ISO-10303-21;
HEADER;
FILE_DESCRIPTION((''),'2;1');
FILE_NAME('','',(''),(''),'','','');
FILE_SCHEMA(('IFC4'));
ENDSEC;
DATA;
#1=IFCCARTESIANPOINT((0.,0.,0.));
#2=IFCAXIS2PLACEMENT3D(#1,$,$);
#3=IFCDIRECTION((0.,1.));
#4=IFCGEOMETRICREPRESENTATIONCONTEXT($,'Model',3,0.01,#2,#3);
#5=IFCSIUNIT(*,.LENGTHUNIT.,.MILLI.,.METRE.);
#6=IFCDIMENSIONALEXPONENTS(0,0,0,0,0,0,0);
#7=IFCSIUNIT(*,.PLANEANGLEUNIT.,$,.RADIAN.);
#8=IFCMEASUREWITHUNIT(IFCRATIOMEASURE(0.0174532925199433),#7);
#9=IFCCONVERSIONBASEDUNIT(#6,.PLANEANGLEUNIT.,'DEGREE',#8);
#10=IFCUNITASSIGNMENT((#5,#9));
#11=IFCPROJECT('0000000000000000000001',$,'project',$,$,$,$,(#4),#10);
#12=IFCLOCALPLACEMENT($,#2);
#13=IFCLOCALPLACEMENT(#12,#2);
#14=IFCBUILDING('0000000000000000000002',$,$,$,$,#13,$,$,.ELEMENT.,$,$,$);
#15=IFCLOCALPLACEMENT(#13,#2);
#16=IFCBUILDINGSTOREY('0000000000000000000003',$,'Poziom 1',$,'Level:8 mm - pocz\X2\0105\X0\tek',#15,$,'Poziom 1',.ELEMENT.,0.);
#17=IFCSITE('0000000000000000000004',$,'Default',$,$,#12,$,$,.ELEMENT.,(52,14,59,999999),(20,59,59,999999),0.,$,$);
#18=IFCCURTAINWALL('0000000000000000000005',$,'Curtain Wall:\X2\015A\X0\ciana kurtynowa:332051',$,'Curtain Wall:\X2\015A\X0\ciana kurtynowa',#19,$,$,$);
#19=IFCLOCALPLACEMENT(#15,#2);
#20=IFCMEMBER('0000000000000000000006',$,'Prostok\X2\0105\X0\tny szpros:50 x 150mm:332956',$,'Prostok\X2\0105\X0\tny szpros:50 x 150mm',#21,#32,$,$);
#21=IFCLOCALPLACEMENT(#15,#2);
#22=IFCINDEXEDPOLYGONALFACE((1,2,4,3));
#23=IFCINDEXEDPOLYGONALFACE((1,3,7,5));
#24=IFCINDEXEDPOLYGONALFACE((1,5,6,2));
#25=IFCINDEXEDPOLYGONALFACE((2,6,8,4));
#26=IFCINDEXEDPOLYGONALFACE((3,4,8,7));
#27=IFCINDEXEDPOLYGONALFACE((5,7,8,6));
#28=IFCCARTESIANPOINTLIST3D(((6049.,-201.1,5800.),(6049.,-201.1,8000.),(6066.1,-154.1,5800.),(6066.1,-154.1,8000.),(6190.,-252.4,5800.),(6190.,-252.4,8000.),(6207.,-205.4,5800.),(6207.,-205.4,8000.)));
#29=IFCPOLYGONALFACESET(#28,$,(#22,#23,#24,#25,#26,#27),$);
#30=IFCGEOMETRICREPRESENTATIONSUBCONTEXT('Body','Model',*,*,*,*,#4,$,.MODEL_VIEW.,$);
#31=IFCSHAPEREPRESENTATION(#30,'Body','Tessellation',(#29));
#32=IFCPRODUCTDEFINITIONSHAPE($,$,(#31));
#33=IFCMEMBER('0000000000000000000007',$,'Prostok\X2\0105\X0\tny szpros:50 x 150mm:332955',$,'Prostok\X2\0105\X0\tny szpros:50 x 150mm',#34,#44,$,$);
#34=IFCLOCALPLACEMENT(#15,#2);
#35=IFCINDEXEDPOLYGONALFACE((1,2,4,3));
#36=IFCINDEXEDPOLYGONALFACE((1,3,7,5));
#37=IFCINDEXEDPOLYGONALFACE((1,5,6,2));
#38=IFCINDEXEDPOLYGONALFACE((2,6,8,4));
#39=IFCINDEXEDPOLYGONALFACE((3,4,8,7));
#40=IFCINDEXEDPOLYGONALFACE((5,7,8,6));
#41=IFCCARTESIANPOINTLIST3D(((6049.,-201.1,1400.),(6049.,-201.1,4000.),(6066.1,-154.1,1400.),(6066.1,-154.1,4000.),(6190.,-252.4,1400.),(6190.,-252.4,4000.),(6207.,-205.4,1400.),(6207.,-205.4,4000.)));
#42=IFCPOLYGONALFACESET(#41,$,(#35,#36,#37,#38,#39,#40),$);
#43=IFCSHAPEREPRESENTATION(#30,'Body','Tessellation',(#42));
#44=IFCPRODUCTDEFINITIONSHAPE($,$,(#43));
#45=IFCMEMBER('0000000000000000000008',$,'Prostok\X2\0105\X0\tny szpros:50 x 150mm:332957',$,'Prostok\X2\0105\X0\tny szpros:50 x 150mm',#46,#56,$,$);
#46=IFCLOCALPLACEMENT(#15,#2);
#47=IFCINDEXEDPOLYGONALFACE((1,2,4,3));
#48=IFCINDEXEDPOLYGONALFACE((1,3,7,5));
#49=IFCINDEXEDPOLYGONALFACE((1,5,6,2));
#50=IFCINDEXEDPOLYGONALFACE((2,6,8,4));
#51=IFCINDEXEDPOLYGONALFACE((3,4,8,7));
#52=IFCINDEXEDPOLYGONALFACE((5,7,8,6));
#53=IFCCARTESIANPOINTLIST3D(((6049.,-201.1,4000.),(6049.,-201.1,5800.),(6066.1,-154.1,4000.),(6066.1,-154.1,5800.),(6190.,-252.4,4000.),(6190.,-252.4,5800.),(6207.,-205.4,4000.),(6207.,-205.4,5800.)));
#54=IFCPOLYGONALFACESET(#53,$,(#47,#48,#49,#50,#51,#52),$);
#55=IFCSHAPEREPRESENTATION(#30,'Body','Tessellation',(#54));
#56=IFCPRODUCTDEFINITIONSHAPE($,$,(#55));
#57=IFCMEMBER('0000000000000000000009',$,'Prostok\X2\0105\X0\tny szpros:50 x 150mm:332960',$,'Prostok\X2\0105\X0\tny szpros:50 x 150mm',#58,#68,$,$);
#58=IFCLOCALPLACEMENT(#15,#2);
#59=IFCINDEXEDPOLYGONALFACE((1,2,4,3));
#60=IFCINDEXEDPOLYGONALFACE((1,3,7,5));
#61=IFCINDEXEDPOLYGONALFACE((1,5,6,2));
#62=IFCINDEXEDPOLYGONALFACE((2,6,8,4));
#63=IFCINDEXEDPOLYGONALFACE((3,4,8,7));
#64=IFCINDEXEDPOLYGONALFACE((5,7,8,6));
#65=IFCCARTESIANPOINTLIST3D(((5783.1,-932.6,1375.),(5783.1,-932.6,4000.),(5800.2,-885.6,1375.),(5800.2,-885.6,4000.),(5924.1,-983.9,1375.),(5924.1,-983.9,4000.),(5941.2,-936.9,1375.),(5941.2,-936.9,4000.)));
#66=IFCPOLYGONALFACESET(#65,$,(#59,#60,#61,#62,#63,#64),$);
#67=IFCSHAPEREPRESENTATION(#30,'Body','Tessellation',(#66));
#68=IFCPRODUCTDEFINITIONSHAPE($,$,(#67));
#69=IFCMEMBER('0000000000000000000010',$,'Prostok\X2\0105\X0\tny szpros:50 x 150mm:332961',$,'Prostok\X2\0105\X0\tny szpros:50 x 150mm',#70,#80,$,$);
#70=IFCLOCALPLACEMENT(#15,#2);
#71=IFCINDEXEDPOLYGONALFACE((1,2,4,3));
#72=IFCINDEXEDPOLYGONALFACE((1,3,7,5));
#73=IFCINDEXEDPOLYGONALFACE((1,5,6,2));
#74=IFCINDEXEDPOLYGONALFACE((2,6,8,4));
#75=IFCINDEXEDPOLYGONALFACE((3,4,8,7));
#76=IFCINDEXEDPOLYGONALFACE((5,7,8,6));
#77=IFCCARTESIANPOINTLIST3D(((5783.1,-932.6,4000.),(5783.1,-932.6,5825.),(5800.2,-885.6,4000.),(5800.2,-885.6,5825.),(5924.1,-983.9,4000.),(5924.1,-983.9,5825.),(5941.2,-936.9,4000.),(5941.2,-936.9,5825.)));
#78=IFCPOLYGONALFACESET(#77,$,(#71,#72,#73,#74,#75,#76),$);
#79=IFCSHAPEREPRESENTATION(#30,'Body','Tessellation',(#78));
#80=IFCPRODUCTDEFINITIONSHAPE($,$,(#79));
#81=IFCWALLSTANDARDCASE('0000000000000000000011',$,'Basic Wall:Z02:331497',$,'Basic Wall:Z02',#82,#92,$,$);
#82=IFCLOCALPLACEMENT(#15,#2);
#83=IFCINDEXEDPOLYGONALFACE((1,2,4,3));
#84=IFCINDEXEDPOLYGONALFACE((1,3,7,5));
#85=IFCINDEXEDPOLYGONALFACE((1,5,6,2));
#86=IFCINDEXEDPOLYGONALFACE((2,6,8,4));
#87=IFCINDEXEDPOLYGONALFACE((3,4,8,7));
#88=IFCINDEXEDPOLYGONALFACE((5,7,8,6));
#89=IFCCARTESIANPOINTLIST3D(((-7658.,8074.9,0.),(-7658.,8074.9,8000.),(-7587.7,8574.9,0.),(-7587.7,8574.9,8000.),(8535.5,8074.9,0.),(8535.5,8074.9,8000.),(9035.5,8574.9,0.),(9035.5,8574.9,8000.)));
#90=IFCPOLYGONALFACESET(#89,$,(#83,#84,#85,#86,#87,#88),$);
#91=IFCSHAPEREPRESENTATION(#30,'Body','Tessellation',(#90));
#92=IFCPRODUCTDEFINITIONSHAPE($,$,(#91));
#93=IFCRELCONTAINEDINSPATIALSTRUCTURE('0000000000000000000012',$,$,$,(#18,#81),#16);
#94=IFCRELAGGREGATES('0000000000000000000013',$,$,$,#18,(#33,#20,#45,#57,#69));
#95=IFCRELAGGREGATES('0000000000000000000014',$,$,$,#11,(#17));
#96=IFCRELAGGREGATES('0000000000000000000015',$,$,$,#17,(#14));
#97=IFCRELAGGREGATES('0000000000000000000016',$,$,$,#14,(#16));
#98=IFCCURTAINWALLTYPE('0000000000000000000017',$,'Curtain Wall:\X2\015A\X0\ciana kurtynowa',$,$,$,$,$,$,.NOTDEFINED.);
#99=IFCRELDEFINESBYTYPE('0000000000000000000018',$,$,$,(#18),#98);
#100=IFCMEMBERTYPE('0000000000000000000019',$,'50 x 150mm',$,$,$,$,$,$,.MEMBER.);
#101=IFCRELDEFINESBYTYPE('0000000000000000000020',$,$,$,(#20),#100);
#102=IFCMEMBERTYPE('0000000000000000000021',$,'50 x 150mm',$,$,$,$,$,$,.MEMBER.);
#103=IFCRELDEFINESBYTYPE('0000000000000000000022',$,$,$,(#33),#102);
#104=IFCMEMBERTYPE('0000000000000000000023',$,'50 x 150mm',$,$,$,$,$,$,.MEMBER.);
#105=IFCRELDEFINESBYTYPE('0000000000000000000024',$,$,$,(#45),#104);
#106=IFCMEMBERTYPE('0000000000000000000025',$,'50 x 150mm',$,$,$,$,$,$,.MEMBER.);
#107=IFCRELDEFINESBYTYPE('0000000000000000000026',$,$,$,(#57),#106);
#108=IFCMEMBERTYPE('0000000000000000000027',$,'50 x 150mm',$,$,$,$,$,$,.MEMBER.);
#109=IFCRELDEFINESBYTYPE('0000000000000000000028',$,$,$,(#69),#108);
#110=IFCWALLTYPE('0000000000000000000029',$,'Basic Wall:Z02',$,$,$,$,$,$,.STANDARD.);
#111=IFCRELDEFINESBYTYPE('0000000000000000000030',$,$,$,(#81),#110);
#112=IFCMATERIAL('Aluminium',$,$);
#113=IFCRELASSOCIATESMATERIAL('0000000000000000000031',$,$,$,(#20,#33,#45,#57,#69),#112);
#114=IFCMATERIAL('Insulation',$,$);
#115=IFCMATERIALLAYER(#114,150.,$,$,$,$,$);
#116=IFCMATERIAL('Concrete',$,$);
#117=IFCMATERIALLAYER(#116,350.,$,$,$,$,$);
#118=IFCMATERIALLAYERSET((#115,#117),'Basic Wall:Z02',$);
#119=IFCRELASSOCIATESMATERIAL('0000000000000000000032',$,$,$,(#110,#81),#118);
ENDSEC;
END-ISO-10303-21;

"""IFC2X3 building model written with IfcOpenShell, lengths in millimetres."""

from ifc_helpers import new_model, entity, si_unit, converted_unit, direction, frame, origin, origin_2d_with_axis, place, context, subcontext, project, spatial, polyline, rectangle, outline, extrude, source, transform, mapped, material, layer, layer_set, layer_usage, type_object, type_shapes, element, aggregate, save


model = new_model("IFC2X3")

# Units and contexts
model_context = context("Model", 3, precision=0.01, world=origin(), true_north=direction((0.0, 1.0)))
body_context = subcontext(model_context, "Body", "Model", "MODEL_VIEW")
ifc_project = project(units=[si_unit("LENGTHUNIT", "METRE", prefix="MILLI"), converted_unit("PLANEANGLEUNIT", "DEGREE", entity("IfcRatioMeasure", 0.0174532925199433), si_unit("PLANEANGLEUNIT", "RADIAN"), dimensions=[0, 0, 0, 0, 0, 0, 0])], contexts=[model_context])

# Site, building, storey
site_placement = place(None, origin())
site = spatial("IfcSite", under=ifc_project, at=site_placement, Name="Default", CompositionType="ELEMENT", RefLatitude=(52, 14, 59, 999999), RefLongitude=(20, 59, 59, 999999), RefElevation=0.0)
building_placement = place(site_placement, origin())
building = spatial("IfcBuilding", under=site, at=building_placement, CompositionType="ELEMENT")
storey_placement = place(building_placement, origin())
storey = spatial("IfcBuildingStorey", under=building, at=storey_placement, Name="Poziom 1", ObjectType="Level:8 mm - początek", LongName="Poziom 1", CompositionType="ELEMENT", Elevation=0.0)

# Curtain wall, members
curtain_wall_type = type_object("IfcCurtainWallType", Name="Curtain Wall:Ściana kurtynowa", PredefinedType="NOTDEFINED")
curtain_wall_placement = place(storey_placement, origin())
curtain_wall = element("IfcCurtainWall", 1, at=curtain_wall_placement, inside=storey, type_object=curtain_wall_type, Name="Curtain Wall:Ściana kurtynowa:332051", ObjectType="Curtain Wall:Ściana kurtynowa")
ifc_material_1 = material(Name="Aluminium")
member_type_1 = type_object("IfcMemberType", Name="50 x 150mm", PredefinedType="MEMBER")
shared_shape_1 = source(origin(), body_context, "Body", "SweptSolid", [
    extrude(rectangle(XDim=150.0, YDim=50.0, at=origin_2d_with_axis()), frame((0.0, 0.0, -2200.0), z_axis=(0.0, 0.0, 1.0), x_axis=(0.0, -1.0, 0.0)), (0.0, 0.0, 1.0), 2200.0),
])
type_shapes(member_type_1, [shared_shape_1])
member_1_placement = place(storey_placement, frame((6128.0, -203.2, 5800.0), z_axis=(0.0, 0.0, -1.0), x_axis=(0.341586, 0.939851, 0.0)))
member_1 = element("IfcMember", 2, at=member_1_placement, type_object=member_type_1, material=ifc_material_1, Name="Prostokątny szpros:50 x 150mm:332956", ObjectType="Prostokątny szpros:50 x 150mm", context=body_context, shape_type="MappedRepresentation", body=[
    mapped(shared_shape_1, transform((0.0, 0.0, 0.0), scale=1.0)),
])
member_type_2 = type_object("IfcMemberType", Name="50 x 150mm", PredefinedType="MEMBER")
shared_shape_2 = source(origin(), body_context, "Body", "SweptSolid", [
    extrude(rectangle(XDim=150.0, YDim=50.0, at=origin_2d_with_axis()), frame((0.0, 0.0, -2600.0), z_axis=(0.0, 0.0, 1.0), x_axis=(0.0, -1.0, 0.0)), (0.0, 0.0, 1.0), 2600.0),
])
type_shapes(member_type_2, [shared_shape_2])
member_2_placement = place(storey_placement, frame((6128.0, -203.2, 1400.0), z_axis=(0.0, 0.0, -1.0), x_axis=(0.341586, 0.939851, 0.0)))
member_2 = element("IfcMember", 3, at=member_2_placement, type_object=member_type_2, material=ifc_material_1, Name="Prostokątny szpros:50 x 150mm:332955", ObjectType="Prostokątny szpros:50 x 150mm", context=body_context, shape_type="MappedRepresentation", body=[
    mapped(shared_shape_2, transform((0.0, 0.0, 0.0), scale=1.0)),
])
member_type_3 = type_object("IfcMemberType", Name="50 x 150mm", PredefinedType="MEMBER")
shared_shape_3 = source(origin(), body_context, "Body", "SweptSolid", [
    extrude(rectangle(XDim=150.0, YDim=50.0, at=origin_2d_with_axis()), frame((0.0, 0.0, -1800.0), z_axis=(0.0, 0.0, 1.0), x_axis=(0.0, -1.0, 0.0)), (0.0, 0.0, 1.0), 1800.0),
])
type_shapes(member_type_3, [shared_shape_3])
member_3_placement = place(storey_placement, frame((6128.0, -203.2, 4000.0), z_axis=(0.0, 0.0, -1.0), x_axis=(0.341586, 0.939851, 0.0)))
member_3 = element("IfcMember", 4, at=member_3_placement, type_object=member_type_3, material=ifc_material_1, Name="Prostokątny szpros:50 x 150mm:332957", ObjectType="Prostokątny szpros:50 x 150mm", context=body_context, shape_type="MappedRepresentation", body=[
    mapped(shared_shape_3, transform((0.0, 0.0, 0.0), scale=1.0)),
])
member_type_4 = type_object("IfcMemberType", Name="50 x 150mm", PredefinedType="MEMBER")
shared_shape_4 = source(origin(), body_context, "Body", "SweptSolid", [
    extrude(rectangle(XDim=150.0, YDim=50.0, at=origin_2d_with_axis()), frame((0.0, 0.0, -2625.0), z_axis=(0.0, 0.0, 1.0), x_axis=(0.0, -1.0, 0.0)), (0.0, 0.0, 1.0), 2625.0),
])
type_shapes(member_type_4, [shared_shape_4])
member_4_placement = place(storey_placement, frame((5862.1, -934.8, 1375.0), z_axis=(0.0, 0.0, -1.0), x_axis=(0.341586, 0.939851, 0.0)))
member_4 = element("IfcMember", 5, at=member_4_placement, type_object=member_type_4, material=ifc_material_1, Name="Prostokątny szpros:50 x 150mm:332960", ObjectType="Prostokątny szpros:50 x 150mm", context=body_context, shape_type="MappedRepresentation", body=[
    mapped(shared_shape_4, transform((0.0, 0.0, 0.0), scale=1.0)),
])
member_type_5 = type_object("IfcMemberType", Name="50 x 150mm", PredefinedType="MEMBER")
shared_shape_5 = source(origin(), body_context, "Body", "SweptSolid", [
    extrude(rectangle(XDim=150.0, YDim=50.0, at=origin_2d_with_axis()), frame((0.0, 0.0, -1825.0), z_axis=(0.0, 0.0, 1.0), x_axis=(0.0, -1.0, 0.0)), (0.0, 0.0, 1.0), 1825.0),
])
type_shapes(member_type_5, [shared_shape_5])
member_5_placement = place(storey_placement, frame((5862.1, -934.8, 4000.0), z_axis=(0.0, 0.0, -1.0), x_axis=(0.341586, 0.939851, 0.0)))
member_5 = element("IfcMember", 6, at=member_5_placement, type_object=member_type_5, material=ifc_material_1, Name="Prostokątny szpros:50 x 150mm:332961", ObjectType="Prostokątny szpros:50 x 150mm", context=body_context, shape_type="MappedRepresentation", body=[
    mapped(shared_shape_5, transform((0.0, 0.0, 0.0), scale=1.0)),
])
aggregate(curtain_wall, [member_2, member_1, member_3, member_4, member_5])

# Wall
ifc_material_2 = material(Name="Insulation")
ifc_layer_1 = layer(ifc_material_2, 150.0)
ifc_material_3 = material(Name="Concrete")
ifc_layer_2 = layer(ifc_material_3, 350.0)
ifc_layer_set_1 = layer_set([ifc_layer_1, ifc_layer_2], Name="Basic Wall:Z02")
ifc_layer_usage_1 = layer_usage(ifc_layer_set_1, "AXIS2", "NEGATIVE", 250.0)
wall_type = type_object("IfcWallType", Name="Basic Wall:Z02", PredefinedType="STANDARD", material=ifc_layer_set_1)
wall_placement = place(storey_placement, frame((9035.5, 8324.9, 0.0), z_axis=(0.0, 0.0, 1.0), x_axis=(-1.0, 0.0, 0.0)))
element("IfcWallStandardCase", 7, at=wall_placement, inside=storey, type_object=wall_type, material=ifc_layer_usage_1, Name="Basic Wall:Z02:331497", ObjectType="Basic Wall:Z02", context=body_context, shape_type="SweptSolid", body=[
    extrude(outline(polyline([(16623.2, -250.0), (16693.5, 250.0), (500.0, 250.0), (0.0, -250.0), (16623.2, -250.0)])), origin(), (0.0, 0.0, 1.0), 8000.0),
])

save(model, "model.ifc")
